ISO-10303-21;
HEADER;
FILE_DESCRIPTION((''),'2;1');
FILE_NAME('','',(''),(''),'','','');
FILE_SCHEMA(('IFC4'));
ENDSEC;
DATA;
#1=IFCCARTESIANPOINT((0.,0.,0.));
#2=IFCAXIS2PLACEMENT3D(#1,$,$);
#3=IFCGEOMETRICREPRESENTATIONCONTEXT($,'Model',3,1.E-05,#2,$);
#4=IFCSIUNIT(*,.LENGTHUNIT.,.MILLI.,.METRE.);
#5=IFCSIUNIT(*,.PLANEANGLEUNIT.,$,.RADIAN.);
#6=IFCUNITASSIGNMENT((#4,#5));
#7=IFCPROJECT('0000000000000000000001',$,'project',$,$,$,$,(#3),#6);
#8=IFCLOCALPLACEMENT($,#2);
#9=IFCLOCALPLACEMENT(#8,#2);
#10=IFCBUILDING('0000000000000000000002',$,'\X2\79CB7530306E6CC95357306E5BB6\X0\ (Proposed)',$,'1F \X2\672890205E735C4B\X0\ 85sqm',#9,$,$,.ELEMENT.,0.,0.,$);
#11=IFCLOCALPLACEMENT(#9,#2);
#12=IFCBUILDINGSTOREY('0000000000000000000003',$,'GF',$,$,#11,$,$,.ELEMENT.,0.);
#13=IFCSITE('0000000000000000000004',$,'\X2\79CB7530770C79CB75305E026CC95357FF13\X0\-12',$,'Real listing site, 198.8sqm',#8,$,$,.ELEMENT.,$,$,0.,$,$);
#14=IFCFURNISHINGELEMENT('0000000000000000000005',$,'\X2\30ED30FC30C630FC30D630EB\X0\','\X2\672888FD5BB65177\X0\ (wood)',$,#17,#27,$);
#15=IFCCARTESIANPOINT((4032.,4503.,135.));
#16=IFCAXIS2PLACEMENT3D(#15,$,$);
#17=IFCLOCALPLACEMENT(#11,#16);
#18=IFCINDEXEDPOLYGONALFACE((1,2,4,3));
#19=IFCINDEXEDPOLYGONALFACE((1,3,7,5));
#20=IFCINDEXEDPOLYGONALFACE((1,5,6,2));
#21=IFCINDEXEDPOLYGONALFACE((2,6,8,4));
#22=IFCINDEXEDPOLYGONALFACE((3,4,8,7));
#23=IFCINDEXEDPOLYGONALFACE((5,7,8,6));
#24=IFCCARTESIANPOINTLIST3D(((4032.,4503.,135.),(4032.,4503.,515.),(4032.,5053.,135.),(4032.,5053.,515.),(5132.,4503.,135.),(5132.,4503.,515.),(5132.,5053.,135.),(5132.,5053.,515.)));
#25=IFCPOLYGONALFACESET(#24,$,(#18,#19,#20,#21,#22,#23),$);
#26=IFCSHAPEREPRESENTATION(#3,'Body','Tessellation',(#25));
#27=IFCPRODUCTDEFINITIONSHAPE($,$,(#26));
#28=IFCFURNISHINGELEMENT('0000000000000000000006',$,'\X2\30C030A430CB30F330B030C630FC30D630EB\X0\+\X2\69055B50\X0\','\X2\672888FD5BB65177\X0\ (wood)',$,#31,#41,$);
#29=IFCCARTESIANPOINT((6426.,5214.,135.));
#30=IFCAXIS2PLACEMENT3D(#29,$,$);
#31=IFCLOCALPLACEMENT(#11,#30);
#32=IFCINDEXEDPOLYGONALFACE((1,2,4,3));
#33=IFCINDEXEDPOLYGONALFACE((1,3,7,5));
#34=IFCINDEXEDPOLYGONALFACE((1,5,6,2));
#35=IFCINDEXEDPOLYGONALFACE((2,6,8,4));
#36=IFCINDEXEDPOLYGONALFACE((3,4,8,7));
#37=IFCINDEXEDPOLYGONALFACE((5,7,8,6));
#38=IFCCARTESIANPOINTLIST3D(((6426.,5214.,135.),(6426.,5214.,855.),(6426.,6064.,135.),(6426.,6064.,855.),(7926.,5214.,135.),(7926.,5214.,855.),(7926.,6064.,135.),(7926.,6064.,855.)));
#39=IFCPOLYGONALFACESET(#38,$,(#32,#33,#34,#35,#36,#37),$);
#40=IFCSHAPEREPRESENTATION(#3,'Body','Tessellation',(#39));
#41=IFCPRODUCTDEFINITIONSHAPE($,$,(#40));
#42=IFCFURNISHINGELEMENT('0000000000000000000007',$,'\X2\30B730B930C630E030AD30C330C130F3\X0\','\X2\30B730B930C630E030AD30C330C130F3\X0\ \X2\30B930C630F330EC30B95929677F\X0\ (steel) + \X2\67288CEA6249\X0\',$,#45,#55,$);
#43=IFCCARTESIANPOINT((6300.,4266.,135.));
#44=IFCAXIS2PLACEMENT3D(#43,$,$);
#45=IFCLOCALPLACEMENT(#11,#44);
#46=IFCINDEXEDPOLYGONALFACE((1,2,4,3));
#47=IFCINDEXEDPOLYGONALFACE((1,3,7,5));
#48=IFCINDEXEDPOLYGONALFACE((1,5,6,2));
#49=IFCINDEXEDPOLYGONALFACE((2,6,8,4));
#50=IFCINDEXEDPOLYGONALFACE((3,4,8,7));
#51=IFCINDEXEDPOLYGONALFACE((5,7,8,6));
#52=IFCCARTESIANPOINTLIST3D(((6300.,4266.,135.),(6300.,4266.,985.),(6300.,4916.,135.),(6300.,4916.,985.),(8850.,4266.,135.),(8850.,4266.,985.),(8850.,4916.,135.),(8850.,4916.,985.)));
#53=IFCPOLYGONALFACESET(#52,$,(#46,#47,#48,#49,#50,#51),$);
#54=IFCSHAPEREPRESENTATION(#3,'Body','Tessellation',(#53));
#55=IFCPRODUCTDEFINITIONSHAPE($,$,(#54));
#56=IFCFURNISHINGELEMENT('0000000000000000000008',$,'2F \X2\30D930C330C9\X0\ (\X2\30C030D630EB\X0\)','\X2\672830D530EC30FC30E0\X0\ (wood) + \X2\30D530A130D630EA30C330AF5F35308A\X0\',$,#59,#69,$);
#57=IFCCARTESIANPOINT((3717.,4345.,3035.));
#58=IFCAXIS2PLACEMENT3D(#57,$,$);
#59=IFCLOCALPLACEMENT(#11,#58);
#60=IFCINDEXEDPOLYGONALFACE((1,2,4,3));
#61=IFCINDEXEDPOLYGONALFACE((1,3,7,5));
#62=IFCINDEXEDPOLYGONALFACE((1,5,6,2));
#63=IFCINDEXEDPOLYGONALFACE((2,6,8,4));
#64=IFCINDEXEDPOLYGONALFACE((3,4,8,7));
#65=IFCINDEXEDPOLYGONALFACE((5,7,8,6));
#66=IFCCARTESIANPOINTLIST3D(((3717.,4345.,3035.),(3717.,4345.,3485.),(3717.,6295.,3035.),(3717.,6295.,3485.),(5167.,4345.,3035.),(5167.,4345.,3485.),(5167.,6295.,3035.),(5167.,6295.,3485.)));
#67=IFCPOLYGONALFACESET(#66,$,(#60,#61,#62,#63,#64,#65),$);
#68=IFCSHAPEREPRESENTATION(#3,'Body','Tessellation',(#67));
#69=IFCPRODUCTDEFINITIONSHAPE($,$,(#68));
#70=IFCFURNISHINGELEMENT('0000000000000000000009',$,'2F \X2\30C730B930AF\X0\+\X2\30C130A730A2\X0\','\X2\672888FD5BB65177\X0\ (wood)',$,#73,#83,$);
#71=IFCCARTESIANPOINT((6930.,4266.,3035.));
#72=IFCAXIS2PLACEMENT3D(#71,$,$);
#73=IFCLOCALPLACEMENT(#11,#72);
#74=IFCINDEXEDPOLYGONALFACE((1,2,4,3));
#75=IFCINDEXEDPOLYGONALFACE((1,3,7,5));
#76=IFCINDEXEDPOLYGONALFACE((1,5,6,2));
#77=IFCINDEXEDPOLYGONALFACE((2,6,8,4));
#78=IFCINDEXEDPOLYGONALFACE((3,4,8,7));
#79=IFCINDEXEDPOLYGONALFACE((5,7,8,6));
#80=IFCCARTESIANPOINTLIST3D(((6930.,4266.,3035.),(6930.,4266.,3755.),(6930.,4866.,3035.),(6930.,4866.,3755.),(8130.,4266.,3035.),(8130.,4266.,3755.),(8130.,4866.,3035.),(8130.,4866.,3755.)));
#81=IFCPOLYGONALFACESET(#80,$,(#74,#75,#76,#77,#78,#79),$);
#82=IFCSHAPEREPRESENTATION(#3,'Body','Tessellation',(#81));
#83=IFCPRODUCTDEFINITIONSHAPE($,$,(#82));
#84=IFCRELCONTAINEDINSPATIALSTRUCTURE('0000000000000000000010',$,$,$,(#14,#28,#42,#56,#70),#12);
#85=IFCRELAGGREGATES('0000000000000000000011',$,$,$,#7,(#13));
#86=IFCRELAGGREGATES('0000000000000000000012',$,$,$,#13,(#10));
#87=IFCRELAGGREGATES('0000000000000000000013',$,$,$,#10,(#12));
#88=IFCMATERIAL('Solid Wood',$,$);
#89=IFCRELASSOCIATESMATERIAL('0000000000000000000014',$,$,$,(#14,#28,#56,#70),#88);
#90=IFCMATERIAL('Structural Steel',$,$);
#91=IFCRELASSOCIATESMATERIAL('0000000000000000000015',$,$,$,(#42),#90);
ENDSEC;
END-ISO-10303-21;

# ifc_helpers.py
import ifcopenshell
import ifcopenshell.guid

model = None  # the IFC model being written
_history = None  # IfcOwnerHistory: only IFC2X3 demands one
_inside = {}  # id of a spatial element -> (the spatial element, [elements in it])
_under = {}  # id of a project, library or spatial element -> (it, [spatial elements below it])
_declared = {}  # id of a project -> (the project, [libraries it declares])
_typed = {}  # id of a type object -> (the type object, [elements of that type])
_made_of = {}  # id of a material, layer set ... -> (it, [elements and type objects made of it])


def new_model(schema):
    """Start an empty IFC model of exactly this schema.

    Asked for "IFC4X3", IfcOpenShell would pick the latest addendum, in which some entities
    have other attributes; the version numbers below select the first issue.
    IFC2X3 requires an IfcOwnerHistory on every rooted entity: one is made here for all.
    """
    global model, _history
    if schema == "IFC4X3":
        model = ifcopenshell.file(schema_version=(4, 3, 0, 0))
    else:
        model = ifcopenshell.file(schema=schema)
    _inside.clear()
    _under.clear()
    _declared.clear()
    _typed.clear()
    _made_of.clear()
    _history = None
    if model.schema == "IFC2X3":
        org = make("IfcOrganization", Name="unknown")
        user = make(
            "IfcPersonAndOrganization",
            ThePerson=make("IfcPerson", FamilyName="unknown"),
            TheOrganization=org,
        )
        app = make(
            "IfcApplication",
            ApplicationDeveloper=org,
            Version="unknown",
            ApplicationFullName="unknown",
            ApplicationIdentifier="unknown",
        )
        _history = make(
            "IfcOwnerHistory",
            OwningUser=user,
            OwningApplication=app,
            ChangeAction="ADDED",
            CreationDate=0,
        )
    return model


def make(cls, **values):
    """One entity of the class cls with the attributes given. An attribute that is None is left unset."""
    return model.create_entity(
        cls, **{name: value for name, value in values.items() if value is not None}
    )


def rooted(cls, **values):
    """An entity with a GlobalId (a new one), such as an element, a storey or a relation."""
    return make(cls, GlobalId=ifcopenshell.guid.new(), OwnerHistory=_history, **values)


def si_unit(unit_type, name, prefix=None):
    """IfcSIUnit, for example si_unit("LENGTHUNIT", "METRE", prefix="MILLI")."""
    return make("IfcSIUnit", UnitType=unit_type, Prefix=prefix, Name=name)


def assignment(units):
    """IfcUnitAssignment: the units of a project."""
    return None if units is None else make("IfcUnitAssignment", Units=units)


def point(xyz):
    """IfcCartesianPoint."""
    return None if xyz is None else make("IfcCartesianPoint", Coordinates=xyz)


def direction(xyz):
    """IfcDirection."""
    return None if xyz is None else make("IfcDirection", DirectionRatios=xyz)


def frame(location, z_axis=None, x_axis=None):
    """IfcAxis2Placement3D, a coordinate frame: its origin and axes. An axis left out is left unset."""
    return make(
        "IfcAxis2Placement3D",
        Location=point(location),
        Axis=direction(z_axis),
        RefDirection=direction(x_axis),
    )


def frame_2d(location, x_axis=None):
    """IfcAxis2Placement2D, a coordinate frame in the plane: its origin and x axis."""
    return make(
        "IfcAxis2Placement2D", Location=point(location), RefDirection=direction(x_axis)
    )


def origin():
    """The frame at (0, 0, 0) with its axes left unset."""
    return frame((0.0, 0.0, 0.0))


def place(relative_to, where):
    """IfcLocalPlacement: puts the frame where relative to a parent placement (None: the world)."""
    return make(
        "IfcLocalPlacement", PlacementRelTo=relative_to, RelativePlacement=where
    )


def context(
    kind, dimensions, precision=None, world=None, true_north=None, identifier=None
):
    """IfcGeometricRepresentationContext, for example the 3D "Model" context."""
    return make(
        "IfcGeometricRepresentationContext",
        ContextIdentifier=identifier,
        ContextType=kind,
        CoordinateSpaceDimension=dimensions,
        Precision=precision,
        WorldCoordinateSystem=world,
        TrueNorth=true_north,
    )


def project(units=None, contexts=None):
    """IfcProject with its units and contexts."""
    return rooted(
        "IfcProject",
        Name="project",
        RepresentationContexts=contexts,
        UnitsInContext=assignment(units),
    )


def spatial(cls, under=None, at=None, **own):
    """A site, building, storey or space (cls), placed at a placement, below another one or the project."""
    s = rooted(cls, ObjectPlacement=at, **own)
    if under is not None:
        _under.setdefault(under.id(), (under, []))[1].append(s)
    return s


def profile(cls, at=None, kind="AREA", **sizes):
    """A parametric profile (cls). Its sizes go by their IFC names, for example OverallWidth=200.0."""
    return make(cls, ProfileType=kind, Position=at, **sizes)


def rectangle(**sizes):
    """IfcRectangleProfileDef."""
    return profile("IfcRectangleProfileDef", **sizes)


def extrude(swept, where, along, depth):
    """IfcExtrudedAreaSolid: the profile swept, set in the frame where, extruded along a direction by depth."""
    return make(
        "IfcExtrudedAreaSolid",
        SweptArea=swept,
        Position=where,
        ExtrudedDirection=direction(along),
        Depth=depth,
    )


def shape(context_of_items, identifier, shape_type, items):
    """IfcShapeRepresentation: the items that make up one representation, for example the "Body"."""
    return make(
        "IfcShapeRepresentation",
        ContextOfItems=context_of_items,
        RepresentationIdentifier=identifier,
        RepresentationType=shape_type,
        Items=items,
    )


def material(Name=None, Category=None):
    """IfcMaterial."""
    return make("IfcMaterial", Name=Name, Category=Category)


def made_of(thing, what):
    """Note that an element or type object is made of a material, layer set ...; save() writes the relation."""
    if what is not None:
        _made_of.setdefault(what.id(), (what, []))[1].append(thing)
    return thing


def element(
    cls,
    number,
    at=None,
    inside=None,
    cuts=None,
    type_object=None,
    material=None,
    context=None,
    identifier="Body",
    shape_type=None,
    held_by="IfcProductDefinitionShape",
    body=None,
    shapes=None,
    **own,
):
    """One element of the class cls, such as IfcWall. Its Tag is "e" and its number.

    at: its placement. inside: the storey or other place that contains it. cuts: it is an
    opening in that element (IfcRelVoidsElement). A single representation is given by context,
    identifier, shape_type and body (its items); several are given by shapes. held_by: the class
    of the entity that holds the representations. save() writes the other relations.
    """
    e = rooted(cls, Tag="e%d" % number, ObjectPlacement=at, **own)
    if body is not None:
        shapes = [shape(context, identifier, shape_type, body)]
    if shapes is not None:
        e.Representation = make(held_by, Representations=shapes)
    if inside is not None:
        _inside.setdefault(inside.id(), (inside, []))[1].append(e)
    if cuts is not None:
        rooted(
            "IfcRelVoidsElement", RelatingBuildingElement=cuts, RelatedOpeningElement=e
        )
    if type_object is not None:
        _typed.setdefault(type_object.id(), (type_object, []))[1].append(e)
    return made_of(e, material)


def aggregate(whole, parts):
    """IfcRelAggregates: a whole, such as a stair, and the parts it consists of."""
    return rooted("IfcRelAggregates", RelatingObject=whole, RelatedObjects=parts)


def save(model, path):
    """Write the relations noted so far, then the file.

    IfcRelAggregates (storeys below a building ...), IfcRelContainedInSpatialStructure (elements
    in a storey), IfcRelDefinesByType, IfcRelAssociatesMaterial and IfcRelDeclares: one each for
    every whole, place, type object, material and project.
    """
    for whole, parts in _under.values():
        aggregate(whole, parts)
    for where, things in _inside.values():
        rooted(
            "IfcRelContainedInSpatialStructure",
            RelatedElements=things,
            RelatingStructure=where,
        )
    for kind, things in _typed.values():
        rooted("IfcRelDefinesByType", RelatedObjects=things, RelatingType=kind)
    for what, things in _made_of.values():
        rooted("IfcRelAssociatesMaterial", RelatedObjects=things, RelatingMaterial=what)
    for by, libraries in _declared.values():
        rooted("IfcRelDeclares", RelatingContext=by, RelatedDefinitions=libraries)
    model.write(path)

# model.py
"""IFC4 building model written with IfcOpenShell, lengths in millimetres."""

from ifc_helpers import new_model, si_unit, frame, frame_2d, origin, place, context, project, spatial, rectangle, extrude, material, element, save


model = new_model("IFC4")

# Units and contexts
model_context = context("Model", 3, precision=1e-05, world=origin())
ifc_project = project(units=[si_unit("LENGTHUNIT", "METRE", prefix="MILLI"), si_unit("PLANEANGLEUNIT", "RADIAN")], contexts=[model_context])

# Site, building, storey
site_placement = place(None, origin())
site = spatial("IfcSite", under=ifc_project, at=site_placement, Name="秋田県秋田市泉南３-12", ObjectType="Real listing site, 198.8sqm", CompositionType="ELEMENT", RefElevation=0.0)
building_placement = place(site_placement, origin())
building = spatial("IfcBuilding", under=site, at=building_placement, Name="秋田の泉南の家 (Proposed)", ObjectType="1F 木造平屋 85sqm", CompositionType="ELEMENT", ElevationOfRefHeight=0.0, ElevationOfTerrain=0.0)
storey_placement = place(building_placement, origin())
storey = spatial("IfcBuildingStorey", under=building, at=storey_placement, Name="GF", CompositionType="ELEMENT", Elevation=0.0)

# Shared definitions
ifc_material_1 = material(Name="Solid Wood")

# Shared definitions
ifc_material_2 = material(Name="Structural Steel")

# Furnishing elements
furnishing_1_placement = place(storey_placement, frame((4032.0, 4503.0, 135.0)))
element("IfcFurnishingElement", 1, at=furnishing_1_placement, inside=storey, material=ifc_material_1, Name="ローテーブル", Description="木製家具 (wood)", context=model_context, shape_type="SweptSolid", body=[
    extrude(rectangle(XDim=1100.0, YDim=550.0, at=frame_2d((550.0, 275.0))), frame((4032.0, 4503.0, 135.0)), (0.0, 0.0, 1.0), 380.0),
])
furnishing_2_placement = place(storey_placement, frame((6426.0, 5214.0, 135.0)))
element("IfcFurnishingElement", 2, at=furnishing_2_placement, inside=storey, material=ifc_material_1, Name="ダイニングテーブル+椅子", Description="木製家具 (wood)", context=model_context, shape_type="SweptSolid", body=[
    extrude(rectangle(XDim=1500.0, YDim=850.0, at=frame_2d((750.0, 425.0))), frame((6426.0, 5214.0, 135.0)), (0.0, 0.0, 1.0), 720.0),
])
furnishing_3_placement = place(storey_placement, frame((6300.0, 4266.0, 135.0)))
element("IfcFurnishingElement", 3, at=furnishing_3_placement, inside=storey, material=ifc_material_2, Name="システムキッチン", Description="システムキッチン ステンレス天板 (steel) + 木質扉", context=model_context, shape_type="SweptSolid", body=[
    extrude(rectangle(XDim=2550.0, YDim=650.0, at=frame_2d((1275.0, 325.0))), frame((6300.0, 4266.0, 135.0)), (0.0, 0.0, 1.0), 850.0),
])
furnishing_4_placement = place(storey_placement, frame((3717.0, 4345.0, 3035.0)))
element("IfcFurnishingElement", 4, at=furnishing_4_placement, inside=storey, material=ifc_material_1, Name="2F ベッド (ダブル)", Description="木フレーム (wood) + ファブリック張り", context=model_context, shape_type="SweptSolid", body=[
    extrude(rectangle(XDim=1450.0, YDim=1950.0, at=frame_2d((725.0, 975.0))), frame((3717.0, 4345.0, 3035.0)), (0.0, 0.0, 1.0), 450.0),
])
furnishing_5_placement = place(storey_placement, frame((6930.0, 4266.0, 3035.0)))
element("IfcFurnishingElement", 5, at=furnishing_5_placement, inside=storey, material=ifc_material_1, Name="2F デスク+チェア", Description="木製家具 (wood)", context=model_context, shape_type="SweptSolid", body=[
    extrude(rectangle(XDim=1200.0, YDim=600.0, at=frame_2d((600.0, 300.0))), frame((6930.0, 4266.0, 3035.0)), (0.0, 0.0, 1.0), 720.0),
])

save(model, "model.ifc")
